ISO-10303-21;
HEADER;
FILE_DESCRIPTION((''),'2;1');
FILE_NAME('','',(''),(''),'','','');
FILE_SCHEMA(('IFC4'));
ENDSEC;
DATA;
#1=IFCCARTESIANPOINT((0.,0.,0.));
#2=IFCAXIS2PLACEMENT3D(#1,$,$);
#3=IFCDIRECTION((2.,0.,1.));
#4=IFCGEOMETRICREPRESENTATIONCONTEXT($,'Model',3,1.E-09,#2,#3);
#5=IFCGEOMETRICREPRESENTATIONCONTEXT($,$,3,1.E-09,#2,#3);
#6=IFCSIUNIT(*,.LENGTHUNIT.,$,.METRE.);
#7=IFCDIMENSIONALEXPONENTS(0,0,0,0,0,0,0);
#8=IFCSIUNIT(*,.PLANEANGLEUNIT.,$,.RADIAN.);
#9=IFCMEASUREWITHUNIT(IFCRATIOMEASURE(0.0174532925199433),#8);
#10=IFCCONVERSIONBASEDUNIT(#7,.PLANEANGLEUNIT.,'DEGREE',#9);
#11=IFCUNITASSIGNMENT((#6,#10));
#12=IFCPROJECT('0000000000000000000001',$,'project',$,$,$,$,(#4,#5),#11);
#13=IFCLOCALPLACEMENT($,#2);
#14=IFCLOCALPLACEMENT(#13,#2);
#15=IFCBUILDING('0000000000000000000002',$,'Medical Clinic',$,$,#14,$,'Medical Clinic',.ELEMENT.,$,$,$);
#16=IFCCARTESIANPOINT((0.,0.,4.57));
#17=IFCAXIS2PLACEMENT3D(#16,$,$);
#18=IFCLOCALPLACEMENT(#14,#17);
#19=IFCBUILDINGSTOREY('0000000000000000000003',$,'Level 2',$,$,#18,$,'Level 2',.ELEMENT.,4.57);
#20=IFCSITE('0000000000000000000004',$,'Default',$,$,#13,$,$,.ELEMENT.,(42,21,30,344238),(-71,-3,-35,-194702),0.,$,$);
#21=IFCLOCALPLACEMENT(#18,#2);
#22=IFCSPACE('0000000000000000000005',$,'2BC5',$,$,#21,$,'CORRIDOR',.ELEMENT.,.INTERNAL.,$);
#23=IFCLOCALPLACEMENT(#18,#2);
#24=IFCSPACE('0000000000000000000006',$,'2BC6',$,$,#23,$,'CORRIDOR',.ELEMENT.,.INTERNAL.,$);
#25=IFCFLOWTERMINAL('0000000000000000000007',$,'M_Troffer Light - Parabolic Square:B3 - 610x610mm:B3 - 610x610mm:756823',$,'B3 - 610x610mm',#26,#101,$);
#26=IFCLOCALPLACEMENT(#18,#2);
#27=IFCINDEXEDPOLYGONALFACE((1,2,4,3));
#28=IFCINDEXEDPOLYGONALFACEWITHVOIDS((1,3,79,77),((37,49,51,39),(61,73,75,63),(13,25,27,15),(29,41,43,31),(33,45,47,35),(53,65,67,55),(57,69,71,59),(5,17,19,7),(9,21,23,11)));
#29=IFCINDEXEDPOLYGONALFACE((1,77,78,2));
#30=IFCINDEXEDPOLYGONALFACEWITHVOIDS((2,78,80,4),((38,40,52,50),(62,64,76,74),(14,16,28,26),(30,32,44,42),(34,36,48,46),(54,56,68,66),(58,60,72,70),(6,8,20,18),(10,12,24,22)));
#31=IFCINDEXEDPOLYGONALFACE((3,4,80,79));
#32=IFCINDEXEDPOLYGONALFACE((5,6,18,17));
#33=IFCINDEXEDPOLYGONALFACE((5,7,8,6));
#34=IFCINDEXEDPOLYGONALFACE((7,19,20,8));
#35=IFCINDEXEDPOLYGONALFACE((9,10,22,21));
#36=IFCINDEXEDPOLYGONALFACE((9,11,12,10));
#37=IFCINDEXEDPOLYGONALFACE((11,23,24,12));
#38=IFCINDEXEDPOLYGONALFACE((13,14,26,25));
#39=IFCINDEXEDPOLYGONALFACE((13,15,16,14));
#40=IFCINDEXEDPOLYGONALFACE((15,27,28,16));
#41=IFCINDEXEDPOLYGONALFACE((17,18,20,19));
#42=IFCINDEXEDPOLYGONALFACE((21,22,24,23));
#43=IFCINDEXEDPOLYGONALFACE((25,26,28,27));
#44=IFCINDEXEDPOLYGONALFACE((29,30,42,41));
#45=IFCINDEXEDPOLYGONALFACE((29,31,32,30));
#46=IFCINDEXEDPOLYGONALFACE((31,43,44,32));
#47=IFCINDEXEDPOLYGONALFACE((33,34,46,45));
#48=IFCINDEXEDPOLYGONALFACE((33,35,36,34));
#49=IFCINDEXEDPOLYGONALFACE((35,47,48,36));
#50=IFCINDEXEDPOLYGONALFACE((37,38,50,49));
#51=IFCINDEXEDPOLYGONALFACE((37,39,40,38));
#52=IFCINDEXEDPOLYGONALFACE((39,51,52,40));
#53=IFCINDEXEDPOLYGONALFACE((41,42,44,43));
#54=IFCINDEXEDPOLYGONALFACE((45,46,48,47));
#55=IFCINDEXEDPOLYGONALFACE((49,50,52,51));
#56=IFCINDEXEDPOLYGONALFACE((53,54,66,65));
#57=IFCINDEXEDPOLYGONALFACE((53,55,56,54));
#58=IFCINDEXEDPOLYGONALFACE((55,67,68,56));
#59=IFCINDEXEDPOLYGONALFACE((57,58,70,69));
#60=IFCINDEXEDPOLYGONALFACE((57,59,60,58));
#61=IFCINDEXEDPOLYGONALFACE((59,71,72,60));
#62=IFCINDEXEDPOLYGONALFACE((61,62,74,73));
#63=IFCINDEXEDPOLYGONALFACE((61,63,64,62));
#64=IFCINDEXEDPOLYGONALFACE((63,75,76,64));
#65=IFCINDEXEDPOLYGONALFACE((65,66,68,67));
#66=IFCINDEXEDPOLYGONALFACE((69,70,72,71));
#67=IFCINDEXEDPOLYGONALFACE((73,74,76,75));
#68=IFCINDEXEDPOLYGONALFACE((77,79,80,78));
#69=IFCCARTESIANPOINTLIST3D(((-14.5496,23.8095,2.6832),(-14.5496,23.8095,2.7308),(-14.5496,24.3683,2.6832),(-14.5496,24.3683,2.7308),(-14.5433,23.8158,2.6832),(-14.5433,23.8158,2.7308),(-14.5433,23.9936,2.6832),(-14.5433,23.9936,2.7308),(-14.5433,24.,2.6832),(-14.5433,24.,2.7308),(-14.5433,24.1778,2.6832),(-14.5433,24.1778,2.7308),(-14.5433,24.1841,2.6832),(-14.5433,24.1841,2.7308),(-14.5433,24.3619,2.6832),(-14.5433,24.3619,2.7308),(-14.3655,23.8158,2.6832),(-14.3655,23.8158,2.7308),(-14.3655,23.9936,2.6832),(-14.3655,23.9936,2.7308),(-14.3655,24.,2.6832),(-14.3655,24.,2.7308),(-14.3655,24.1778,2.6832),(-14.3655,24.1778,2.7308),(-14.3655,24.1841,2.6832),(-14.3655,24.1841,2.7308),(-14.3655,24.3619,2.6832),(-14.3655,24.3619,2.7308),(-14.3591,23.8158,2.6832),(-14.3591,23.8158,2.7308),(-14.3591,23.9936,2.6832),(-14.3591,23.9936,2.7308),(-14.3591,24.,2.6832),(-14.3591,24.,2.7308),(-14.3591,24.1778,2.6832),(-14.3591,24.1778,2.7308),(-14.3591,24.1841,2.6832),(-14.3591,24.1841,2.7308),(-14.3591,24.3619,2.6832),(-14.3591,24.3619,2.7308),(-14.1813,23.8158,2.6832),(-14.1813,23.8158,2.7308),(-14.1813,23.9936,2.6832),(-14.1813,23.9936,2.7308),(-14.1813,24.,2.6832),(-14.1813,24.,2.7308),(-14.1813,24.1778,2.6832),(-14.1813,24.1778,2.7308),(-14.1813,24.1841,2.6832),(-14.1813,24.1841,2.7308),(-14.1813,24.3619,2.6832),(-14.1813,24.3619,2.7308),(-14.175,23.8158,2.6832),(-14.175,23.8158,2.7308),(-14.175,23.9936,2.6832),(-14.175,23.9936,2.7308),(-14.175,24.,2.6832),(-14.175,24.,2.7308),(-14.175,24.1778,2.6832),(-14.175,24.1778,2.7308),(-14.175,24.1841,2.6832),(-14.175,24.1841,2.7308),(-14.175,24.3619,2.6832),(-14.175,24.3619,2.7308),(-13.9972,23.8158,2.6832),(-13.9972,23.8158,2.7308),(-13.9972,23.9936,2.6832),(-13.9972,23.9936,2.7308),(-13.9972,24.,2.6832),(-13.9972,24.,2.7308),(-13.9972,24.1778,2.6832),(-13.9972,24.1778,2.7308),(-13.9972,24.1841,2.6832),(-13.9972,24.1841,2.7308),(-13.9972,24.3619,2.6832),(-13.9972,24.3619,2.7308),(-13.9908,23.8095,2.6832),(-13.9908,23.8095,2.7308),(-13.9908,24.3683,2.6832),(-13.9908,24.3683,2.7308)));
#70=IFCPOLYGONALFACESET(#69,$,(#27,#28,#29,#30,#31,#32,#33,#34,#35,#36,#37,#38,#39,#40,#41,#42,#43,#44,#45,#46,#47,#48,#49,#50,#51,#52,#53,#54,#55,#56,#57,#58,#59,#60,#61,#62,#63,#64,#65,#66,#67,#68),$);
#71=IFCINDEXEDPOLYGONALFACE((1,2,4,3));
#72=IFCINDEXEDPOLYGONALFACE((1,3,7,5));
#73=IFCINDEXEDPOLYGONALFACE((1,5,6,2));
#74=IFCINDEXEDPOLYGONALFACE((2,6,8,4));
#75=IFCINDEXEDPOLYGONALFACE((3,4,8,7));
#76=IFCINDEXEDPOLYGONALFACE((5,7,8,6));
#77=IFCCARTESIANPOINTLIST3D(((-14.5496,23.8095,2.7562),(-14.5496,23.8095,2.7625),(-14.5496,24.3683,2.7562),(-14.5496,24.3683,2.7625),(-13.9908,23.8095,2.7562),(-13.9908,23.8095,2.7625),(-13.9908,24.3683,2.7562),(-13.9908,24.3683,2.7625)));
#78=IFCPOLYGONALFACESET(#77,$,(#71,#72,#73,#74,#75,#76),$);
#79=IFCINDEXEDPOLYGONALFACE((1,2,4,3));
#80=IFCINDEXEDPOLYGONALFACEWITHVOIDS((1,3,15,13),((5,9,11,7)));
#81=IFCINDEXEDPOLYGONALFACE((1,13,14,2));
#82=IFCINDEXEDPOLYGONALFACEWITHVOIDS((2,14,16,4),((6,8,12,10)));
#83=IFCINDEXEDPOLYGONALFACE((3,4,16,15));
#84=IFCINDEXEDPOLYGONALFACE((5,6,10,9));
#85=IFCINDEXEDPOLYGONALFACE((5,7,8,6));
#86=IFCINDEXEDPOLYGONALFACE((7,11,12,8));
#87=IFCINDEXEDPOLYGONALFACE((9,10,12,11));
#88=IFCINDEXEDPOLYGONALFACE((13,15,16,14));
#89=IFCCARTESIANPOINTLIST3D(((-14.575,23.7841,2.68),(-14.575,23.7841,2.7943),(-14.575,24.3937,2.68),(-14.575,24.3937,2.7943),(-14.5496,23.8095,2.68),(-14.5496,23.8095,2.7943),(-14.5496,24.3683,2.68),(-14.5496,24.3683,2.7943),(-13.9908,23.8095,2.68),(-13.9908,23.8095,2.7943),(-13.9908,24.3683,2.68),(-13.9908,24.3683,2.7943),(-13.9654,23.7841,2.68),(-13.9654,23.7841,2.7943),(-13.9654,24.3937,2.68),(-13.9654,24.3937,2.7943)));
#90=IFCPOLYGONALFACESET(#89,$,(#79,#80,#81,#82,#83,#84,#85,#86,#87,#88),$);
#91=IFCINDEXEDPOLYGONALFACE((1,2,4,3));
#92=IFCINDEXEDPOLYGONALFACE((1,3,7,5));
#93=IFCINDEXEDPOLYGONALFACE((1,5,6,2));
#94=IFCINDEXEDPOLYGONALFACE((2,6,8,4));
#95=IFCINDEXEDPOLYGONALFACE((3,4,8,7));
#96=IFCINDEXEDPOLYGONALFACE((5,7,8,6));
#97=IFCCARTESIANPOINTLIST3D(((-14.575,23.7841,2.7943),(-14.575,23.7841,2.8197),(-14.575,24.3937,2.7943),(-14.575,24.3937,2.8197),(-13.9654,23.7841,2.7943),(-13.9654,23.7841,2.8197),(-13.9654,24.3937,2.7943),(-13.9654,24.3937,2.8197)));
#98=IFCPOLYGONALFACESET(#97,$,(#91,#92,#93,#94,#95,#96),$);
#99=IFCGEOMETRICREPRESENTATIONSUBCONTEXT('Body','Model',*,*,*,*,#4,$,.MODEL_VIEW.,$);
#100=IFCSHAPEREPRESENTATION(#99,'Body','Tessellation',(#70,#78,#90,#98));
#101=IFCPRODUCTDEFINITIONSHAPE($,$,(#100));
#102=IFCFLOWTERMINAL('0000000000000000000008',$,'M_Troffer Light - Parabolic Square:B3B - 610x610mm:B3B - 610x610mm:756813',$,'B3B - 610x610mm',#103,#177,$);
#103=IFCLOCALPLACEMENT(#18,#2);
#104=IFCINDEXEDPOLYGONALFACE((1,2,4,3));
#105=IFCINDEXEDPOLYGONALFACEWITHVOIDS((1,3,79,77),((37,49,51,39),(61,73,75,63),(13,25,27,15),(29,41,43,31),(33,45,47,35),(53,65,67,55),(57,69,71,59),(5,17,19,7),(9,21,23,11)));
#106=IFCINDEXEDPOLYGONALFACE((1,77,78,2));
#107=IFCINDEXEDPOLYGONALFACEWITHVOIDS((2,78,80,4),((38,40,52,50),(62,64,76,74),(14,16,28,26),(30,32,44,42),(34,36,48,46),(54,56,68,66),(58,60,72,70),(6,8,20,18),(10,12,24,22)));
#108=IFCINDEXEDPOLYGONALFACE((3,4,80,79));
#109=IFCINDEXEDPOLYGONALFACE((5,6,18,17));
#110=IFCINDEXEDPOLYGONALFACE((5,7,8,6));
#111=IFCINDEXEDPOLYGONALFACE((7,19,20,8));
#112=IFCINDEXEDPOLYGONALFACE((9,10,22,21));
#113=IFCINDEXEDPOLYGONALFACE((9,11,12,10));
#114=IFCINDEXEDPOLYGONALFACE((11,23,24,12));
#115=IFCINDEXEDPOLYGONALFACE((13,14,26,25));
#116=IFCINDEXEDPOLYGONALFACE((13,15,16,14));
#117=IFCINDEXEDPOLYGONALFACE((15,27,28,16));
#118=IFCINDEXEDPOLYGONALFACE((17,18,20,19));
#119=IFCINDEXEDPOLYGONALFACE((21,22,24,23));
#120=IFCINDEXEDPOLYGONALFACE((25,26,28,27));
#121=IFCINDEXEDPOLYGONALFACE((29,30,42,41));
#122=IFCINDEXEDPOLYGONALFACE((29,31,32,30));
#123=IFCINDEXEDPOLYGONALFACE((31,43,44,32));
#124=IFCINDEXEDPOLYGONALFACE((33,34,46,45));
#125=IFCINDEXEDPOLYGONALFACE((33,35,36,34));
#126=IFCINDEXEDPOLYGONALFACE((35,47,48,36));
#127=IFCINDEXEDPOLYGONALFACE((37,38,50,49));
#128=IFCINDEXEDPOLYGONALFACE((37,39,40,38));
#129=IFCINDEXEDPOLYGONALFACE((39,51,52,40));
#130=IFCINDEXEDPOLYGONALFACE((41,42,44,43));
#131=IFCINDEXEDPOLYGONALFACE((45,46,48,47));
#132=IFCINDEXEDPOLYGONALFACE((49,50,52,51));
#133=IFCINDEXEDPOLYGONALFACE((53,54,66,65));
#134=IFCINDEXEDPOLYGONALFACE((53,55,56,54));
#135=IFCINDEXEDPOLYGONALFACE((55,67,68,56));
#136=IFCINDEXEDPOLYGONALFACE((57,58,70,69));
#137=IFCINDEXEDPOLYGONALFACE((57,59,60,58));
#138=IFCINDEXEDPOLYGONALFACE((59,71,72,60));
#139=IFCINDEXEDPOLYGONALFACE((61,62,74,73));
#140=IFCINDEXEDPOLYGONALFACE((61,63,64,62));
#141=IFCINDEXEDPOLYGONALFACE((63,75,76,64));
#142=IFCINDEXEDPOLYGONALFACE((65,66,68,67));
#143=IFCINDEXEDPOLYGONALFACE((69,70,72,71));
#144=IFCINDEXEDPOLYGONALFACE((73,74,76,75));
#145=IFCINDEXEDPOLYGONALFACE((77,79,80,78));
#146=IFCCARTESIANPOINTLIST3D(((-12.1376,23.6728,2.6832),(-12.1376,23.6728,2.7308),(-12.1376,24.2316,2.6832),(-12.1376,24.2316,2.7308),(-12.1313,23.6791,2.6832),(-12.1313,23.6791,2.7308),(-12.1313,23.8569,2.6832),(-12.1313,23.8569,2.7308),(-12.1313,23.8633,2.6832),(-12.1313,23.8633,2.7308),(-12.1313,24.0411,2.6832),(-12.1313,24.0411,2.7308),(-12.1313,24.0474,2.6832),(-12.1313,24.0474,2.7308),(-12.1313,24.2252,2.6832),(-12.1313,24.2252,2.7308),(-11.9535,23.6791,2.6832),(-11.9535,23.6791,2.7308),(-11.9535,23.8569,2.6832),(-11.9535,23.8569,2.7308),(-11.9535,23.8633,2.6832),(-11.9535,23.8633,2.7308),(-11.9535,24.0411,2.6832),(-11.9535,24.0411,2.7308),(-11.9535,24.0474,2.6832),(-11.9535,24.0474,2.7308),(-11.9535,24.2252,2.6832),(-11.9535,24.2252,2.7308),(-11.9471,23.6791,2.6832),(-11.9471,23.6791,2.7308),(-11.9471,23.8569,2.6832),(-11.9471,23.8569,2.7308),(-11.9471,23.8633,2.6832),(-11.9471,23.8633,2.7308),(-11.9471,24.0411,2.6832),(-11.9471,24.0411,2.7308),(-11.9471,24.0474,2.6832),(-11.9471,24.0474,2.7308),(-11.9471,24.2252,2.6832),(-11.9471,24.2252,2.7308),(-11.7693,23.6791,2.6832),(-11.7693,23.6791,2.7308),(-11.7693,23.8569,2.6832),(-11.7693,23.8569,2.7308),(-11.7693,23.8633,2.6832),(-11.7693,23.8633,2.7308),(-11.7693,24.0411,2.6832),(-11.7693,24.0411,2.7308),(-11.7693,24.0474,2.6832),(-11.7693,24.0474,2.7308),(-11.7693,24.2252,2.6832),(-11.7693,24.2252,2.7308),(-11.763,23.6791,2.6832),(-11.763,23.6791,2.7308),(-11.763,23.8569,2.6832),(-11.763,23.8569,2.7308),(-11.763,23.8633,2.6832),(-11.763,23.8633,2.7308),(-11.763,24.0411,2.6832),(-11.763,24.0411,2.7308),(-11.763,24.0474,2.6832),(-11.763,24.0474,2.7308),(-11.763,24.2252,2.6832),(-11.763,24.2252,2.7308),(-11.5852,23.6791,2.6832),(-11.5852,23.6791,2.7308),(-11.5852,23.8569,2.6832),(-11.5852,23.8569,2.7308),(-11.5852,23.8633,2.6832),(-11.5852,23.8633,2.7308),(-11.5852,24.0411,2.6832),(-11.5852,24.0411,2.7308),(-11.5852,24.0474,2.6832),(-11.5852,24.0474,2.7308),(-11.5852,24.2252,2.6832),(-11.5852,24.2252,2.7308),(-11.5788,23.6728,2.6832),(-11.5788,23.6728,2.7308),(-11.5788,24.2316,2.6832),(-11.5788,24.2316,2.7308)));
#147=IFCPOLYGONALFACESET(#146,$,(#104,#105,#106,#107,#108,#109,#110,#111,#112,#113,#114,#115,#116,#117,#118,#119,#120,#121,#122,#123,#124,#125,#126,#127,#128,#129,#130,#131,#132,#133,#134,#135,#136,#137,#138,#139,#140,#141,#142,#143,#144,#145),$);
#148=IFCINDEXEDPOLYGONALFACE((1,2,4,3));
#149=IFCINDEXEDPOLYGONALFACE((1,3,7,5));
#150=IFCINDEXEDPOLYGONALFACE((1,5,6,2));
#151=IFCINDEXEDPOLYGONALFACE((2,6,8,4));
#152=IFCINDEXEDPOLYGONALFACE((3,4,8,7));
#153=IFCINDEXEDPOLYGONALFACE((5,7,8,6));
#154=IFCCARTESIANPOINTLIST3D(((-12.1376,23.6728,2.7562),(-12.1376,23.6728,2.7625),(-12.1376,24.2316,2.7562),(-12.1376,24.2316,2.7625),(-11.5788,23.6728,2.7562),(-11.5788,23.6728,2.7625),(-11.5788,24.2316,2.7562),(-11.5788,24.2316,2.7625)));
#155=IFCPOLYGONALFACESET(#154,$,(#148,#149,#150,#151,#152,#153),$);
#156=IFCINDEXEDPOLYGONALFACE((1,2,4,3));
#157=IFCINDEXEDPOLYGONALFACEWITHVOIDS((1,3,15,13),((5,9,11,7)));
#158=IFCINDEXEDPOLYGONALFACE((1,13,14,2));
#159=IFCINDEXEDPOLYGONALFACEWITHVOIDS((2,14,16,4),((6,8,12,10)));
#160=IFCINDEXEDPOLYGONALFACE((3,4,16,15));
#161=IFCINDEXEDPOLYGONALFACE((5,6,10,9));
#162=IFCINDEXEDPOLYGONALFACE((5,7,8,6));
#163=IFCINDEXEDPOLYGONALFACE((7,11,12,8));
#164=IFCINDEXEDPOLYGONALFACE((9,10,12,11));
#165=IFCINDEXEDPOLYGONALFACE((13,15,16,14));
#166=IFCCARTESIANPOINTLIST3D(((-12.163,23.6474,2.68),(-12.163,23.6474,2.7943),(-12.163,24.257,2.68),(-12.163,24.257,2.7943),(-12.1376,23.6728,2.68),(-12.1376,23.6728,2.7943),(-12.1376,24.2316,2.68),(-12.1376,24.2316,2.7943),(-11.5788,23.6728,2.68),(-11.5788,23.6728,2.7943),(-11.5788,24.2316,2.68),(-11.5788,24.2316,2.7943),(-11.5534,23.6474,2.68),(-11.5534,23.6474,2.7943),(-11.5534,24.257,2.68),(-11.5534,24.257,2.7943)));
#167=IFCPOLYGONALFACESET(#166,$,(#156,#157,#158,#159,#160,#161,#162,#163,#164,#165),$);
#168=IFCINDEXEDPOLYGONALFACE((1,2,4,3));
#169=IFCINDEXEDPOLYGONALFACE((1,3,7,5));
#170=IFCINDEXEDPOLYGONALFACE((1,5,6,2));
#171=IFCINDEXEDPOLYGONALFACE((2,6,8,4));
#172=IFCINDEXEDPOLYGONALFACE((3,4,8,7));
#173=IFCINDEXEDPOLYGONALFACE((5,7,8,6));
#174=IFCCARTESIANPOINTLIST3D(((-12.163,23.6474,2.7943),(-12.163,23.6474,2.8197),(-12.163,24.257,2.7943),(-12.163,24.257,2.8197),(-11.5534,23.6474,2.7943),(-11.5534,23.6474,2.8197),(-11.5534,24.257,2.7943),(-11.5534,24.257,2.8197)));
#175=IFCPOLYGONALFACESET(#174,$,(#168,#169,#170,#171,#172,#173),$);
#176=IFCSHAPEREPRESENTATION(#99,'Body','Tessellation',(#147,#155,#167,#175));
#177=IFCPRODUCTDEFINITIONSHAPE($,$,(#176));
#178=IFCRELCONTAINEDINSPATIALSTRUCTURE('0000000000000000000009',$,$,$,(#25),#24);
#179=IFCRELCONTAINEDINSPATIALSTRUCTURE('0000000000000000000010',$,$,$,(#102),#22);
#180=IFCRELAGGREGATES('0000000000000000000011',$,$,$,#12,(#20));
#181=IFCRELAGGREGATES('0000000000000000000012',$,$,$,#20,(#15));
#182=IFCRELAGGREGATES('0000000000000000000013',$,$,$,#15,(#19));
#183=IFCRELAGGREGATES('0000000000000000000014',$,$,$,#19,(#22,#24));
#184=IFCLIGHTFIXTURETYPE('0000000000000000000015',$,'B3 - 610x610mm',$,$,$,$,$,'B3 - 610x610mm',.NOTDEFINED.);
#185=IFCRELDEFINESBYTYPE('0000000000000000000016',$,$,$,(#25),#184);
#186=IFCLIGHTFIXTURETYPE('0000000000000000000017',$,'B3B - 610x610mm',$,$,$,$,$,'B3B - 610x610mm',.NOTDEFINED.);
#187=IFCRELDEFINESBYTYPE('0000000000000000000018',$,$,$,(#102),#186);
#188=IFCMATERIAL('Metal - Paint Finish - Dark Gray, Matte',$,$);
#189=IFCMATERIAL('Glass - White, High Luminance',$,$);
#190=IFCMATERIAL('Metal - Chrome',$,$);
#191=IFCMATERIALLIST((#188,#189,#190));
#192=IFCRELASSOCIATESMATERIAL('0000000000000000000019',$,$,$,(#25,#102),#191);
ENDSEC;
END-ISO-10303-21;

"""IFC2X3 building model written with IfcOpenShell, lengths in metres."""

from ifc_helpers import new_model, entity, si_unit, converted_unit, direction, frame, origin, origin_2d_with_axis, place, context, subcontext, project, spatial, polyline, rectangle, outline, extrude, source, transform, mapped, material, material_list, type_object, type_shapes, element, save


model = new_model("IFC2X3")

# Units and contexts
model_context = context("Model", 3, precision=1e-09, world=origin(), true_north=direction((2.0, 0.0, 1.0)))
context_of_model = context(None, 3, precision=1e-09, world=origin(), true_north=direction((2.0, 0.0, 1.0)))
body_context = subcontext(model_context, "Body", "Model", "MODEL_VIEW")
ifc_project = project(units=[si_unit("LENGTHUNIT", "METRE"), converted_unit("PLANEANGLEUNIT", "DEGREE", entity("IfcRatioMeasure", 0.0174532925199433), si_unit("PLANEANGLEUNIT", "RADIAN"), dimensions=[0, 0, 0, 0, 0, 0, 0])], contexts=[model_context, context_of_model])

# Site, building, storey
site_placement = place(None, origin())
site = spatial("IfcSite", under=ifc_project, at=site_placement, Name="Default", CompositionType="ELEMENT", RefLatitude=(42, 21, 30, 344238), RefLongitude=(-71, -3, -35, -194702), RefElevation=0.0)
building_placement = place(site_placement, origin())
building = spatial("IfcBuilding", under=site, at=building_placement, Name="Medical Clinic", LongName="Medical Clinic", CompositionType="ELEMENT")
storey_placement = place(building_placement, frame((0.0, 0.0, 4.57)))
storey = spatial("IfcBuildingStorey", under=building, at=storey_placement, Name="Level 2", LongName="Level 2", CompositionType="ELEMENT", Elevation=4.57)

# Shared definitions
space_1_placement = place(storey_placement, origin())
space_1 = spatial("IfcSpace", under=storey, at=space_1_placement, Name="2BC5", LongName="CORRIDOR", CompositionType="ELEMENT", InteriorOrExteriorSpace="INTERNAL")

# Shared definitions
space_2_placement = place(storey_placement, origin())
space_2 = spatial("IfcSpace", under=storey, at=space_2_placement, Name="2BC6", LongName="CORRIDOR", CompositionType="ELEMENT", InteriorOrExteriorSpace="INTERNAL")

# Flow terminals
ifc_material_1 = material(Name="Metal - Paint Finish - Dark Gray, Matte")
ifc_material_2 = material(Name="Glass - White, High Luminance")
ifc_material_3 = material(Name="Metal - Chrome")
ifc_material_list = material_list([ifc_material_1, ifc_material_2, ifc_material_3])
light_fixture_type_1 = type_object("IfcLightFixtureType", Name="B3 - 610x610mm", ElementType="B3 - 610x610mm", PredefinedType="NOTDEFINED")
shared_shape_1 = source(origin(), body_context, "Body", "SweptSolid", [
    extrude(outline(polyline([(-0.2794, -0.2794), (0.2794, -0.2794), (0.2794, 0.2794), (-0.2794, 0.2794), (-0.2794, -0.2794)]), holes=[polyline([(-0.0952, 0.0953), (-0.273, 0.0953), (-0.273, 0.2731), (-0.0952, 0.2731), (-0.0952, 0.0953)]), polyline([(0.2731, 0.0953), (0.0953, 0.0953), (0.0953, 0.2731), (0.2731, 0.2731), (0.2731, 0.0953)]), polyline([(-0.0889, 0.2731), (0.0889, 0.2731), (0.0889, 0.0953), (-0.0889, 0.0953), (-0.0889, 0.2731)]), polyline([(0.2731, -0.273), (0.0953, -0.273), (0.0953, -0.0952), (0.2731, -0.0952), (0.2731, -0.273)]), polyline([(0.0889, -0.273), (-0.0889, -0.273), (-0.0889, -0.0952), (0.0889, -0.0952), (0.0889, -0.273)]), polyline([(-0.0952, -0.273), (-0.273, -0.273), (-0.273, -0.0952), (-0.0952, -0.0952), (-0.0952, -0.273)]), polyline([(-0.0952, -0.0889), (-0.273, -0.0889), (-0.273, 0.0889), (-0.0952, 0.0889), (-0.0952, -0.0889)]), polyline([(0.0889, -0.0889), (-0.0889, -0.0889), (-0.0889, 0.0889), (0.0889, 0.0889), (0.0889, -0.0889)]), polyline([(0.2731, -0.0889), (0.0953, -0.0889), (0.0953, 0.0889), (0.2731, 0.0889), (0.2731, -0.0889)])]), frame((0.0, -0.3048, -0.0508), z_axis=(0.0, 0.0, 1.0), x_axis=(-1.0, 0.0, 0.0)), (0.0, 0.0, 1.0), 0.0476),
    extrude(rectangle(XDim=0.5588, YDim=0.5588, at=origin_2d_with_axis()), frame((0.0, -0.3048, -0.0825), z_axis=(0.0, 0.0, 1.0), x_axis=(-1.0, 0.0, 0.0)), (0.0, 0.0, 1.0), 0.0064),
    extrude(outline(polyline([(-0.3048, -0.3048), (0.3048, -0.3048), (0.3048, 0.3048), (-0.3048, 0.3048), (-0.3048, -0.3048)]), holes=[polyline([(0.2794, 0.2794), (0.2794, -0.2794), (-0.2794, -0.2794), (-0.2794, 0.2794), (0.2794, 0.2794)])]), frame((0.0, -0.3048, -0.1143)), (0.0, 0.0, 1.0), 0.1143),
    extrude(rectangle(XDim=0.6096, YDim=0.6096, at=origin_2d_with_axis()), frame((0.0, -0.3048, -0.1397), z_axis=(0.0, 0.0, 1.0), x_axis=(-1.0, 0.0, 0.0)), (0.0, 0.0, 1.0), 0.0254),
])
type_shapes(light_fixture_type_1, [shared_shape_1])
flow_terminal_1_placement = place(space_2_placement, frame((-14.2702, 23.7841, 2.68), z_axis=(0.0, 0.0, -1.0), x_axis=(1.0, 0.0, 0.0)))
element("IfcFlowTerminal", 1, at=flow_terminal_1_placement, inside=space_2, type_object=light_fixture_type_1, material=ifc_material_list, Name="M_Troffer Light - Parabolic Square:B3 - 610x610mm:B3 - 610x610mm:756823", ObjectType="B3 - 610x610mm", context=body_context, shape_type="MappedRepresentation", body=[
    mapped(shared_shape_1, transform((0.0, 0.0, 0.0), scale=1.0)),
])
light_fixture_type_2 = type_object("IfcLightFixtureType", Name="B3B - 610x610mm", ElementType="B3B - 610x610mm", PredefinedType="NOTDEFINED")
shared_shape_2 = source(origin(), body_context, "Body", "SweptSolid", [
    extrude(outline(polyline([(-0.2794, -0.2794), (0.2794, -0.2794), (0.2794, 0.2794), (-0.2794, 0.2794), (-0.2794, -0.2794)]), holes=[polyline([(-0.0952, 0.0953), (-0.273, 0.0953), (-0.273, 0.2731), (-0.0952, 0.2731), (-0.0952, 0.0953)]), polyline([(0.2731, 0.0953), (0.0953, 0.0953), (0.0953, 0.2731), (0.2731, 0.2731), (0.2731, 0.0953)]), polyline([(-0.0889, 0.2731), (0.0889, 0.2731), (0.0889, 0.0953), (-0.0889, 0.0953), (-0.0889, 0.2731)]), polyline([(0.2731, -0.273), (0.0953, -0.273), (0.0953, -0.0952), (0.2731, -0.0952), (0.2731, -0.273)]), polyline([(0.0889, -0.273), (-0.0889, -0.273), (-0.0889, -0.0952), (0.0889, -0.0952), (0.0889, -0.273)]), polyline([(-0.0952, -0.273), (-0.273, -0.273), (-0.273, -0.0952), (-0.0952, -0.0952), (-0.0952, -0.273)]), polyline([(-0.0952, -0.0889), (-0.273, -0.0889), (-0.273, 0.0889), (-0.0952, 0.0889), (-0.0952, -0.0889)]), polyline([(0.0889, -0.0889), (-0.0889, -0.0889), (-0.0889, 0.0889), (0.0889, 0.0889), (0.0889, -0.0889)]), polyline([(0.2731, -0.0889), (0.0953, -0.0889), (0.0953, 0.0889), (0.2731, 0.0889), (0.2731, -0.0889)])]), frame((0.0, -0.3048, -0.0508), z_axis=(0.0, 0.0, 1.0), x_axis=(-1.0, 0.0, 0.0)), (0.0, 0.0, 1.0), 0.0476),
    extrude(rectangle(XDim=0.5588, YDim=0.5588, at=origin_2d_with_axis()), frame((0.0, -0.3048, -0.0825), z_axis=(0.0, 0.0, 1.0), x_axis=(-1.0, 0.0, 0.0)), (0.0, 0.0, 1.0), 0.0064),
    extrude(outline(polyline([(-0.3048, -0.3048), (0.3048, -0.3048), (0.3048, 0.3048), (-0.3048, 0.3048), (-0.3048, -0.3048)]), holes=[polyline([(0.2794, 0.2794), (0.2794, -0.2794), (-0.2794, -0.2794), (-0.2794, 0.2794), (0.2794, 0.2794)])]), frame((0.0, -0.3048, -0.1143)), (0.0, 0.0, 1.0), 0.1143),
    extrude(rectangle(XDim=0.6096, YDim=0.6096, at=origin_2d_with_axis()), frame((0.0, -0.3048, -0.1397), z_axis=(0.0, 0.0, 1.0), x_axis=(-1.0, 0.0, 0.0)), (0.0, 0.0, 1.0), 0.0254),
])
type_shapes(light_fixture_type_2, [shared_shape_2])
flow_terminal_2_placement = place(space_1_placement, frame((-11.8582, 23.6474, 2.68), z_axis=(0.0, 0.0, -1.0), x_axis=(1.0, 0.0, 0.0)))
element("IfcFlowTerminal", 2, at=flow_terminal_2_placement, inside=space_1, type_object=light_fixture_type_2, material=ifc_material_list, Name="M_Troffer Light - Parabolic Square:B3B - 610x610mm:B3B - 610x610mm:756813", ObjectType="B3B - 610x610mm", context=body_context, shape_type="MappedRepresentation", body=[
    mapped(shared_shape_2, transform((0.0, 0.0, 0.0), scale=1.0)),
])

save(model, "model.ifc")
